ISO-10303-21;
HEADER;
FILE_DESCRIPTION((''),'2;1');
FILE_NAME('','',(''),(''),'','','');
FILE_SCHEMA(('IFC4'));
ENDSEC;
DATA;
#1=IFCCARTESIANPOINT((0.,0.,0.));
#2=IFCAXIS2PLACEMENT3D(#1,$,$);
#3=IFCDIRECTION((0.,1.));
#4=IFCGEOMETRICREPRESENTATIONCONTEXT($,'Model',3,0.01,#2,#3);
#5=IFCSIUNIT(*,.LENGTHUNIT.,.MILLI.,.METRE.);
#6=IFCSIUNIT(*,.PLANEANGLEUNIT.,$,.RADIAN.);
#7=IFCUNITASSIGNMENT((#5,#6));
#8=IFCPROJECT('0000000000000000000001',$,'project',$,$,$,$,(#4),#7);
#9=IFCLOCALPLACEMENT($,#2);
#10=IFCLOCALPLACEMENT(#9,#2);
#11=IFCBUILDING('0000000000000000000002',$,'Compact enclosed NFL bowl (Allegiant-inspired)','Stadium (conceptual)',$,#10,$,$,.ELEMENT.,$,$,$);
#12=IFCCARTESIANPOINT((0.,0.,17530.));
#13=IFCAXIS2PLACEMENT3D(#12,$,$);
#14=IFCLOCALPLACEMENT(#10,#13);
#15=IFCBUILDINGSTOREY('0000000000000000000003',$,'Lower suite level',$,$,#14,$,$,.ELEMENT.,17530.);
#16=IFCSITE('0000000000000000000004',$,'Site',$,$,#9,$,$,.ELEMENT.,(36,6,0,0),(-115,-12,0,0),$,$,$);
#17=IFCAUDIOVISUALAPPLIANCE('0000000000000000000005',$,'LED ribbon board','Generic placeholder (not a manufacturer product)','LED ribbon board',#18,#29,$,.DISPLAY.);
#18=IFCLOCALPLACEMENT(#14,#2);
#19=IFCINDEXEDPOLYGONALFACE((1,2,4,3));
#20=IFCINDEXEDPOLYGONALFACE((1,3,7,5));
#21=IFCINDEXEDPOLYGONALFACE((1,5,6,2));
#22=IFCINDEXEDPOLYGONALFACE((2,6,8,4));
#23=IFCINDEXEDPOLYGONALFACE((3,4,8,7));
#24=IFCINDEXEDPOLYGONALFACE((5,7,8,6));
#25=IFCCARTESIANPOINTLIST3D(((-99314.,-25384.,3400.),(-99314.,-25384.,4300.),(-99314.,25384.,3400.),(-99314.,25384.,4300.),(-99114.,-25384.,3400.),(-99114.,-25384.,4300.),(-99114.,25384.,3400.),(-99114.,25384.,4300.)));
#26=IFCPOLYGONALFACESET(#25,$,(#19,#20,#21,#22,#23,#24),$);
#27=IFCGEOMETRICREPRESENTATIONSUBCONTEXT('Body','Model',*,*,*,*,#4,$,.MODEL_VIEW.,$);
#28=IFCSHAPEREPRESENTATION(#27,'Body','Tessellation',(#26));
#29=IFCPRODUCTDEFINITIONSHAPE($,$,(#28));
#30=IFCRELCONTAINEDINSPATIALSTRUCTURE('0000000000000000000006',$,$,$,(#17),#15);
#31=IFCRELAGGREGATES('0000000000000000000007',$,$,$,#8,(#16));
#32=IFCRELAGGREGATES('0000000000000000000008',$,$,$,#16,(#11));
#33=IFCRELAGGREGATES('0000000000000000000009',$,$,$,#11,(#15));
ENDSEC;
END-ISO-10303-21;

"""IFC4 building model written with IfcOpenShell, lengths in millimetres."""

from ifc_helpers import new_model, si_unit, direction, frame, origin, place, context, subcontext, project, spatial, line, indexed_curve, outline, extrude, element, save


model = new_model("IFC4")

# Units and contexts
model_context = context("Model", 3, precision=0.01, world=origin(), true_north=direction((0.0, 1.0)))
body_context = subcontext(model_context, "Body", "Model", "MODEL_VIEW")
ifc_project = project(units=[si_unit("LENGTHUNIT", "METRE", prefix="MILLI"), si_unit("PLANEANGLEUNIT", "RADIAN")], contexts=[model_context])

# Site, building, storey
site_placement = place(None, origin())
site = spatial("IfcSite", under=ifc_project, at=site_placement, Name="Site", CompositionType="ELEMENT", RefLatitude=(36, 6, 0, 0), RefLongitude=(-115, -12, 0, 0))
building_placement = place(site_placement, origin())
building = spatial("IfcBuilding", under=site, at=building_placement, Name="Compact enclosed NFL bowl (Allegiant-inspired)", Description="Stadium (conceptual)", CompositionType="ELEMENT")
storey_placement = place(building_placement, frame((0.0, 0.0, 17530.0)))
storey = spatial("IfcBuildingStorey", under=building, at=storey_placement, Name="Lower suite level", CompositionType="ELEMENT", Elevation=17530.0)

# Shared definitions
placement = place(storey_placement, frame((0.0, 0.0, -17530.0)))

# Audio visual appliance
element("IfcAudioVisualAppliance", 1, at=placement, inside=storey, Name="LED ribbon board", Description="Generic placeholder (not a manufacturer product)", ObjectType="LED ribbon board", PredefinedType="DISPLAY", context=body_context, shape_type="SweptSolid", body=[
    extrude(outline(indexed_curve([(-99114.0, 25384.0), (-99114.0, -25384.0), (-99314.0, -25384.0), (-99314.0, 25384.0)], segments=[line(1, 2), line(2, 3), line(3, 4), line(4, 1)], self_intersect=False)), frame((0.0, 0.0, 20930.0)), (0.0, 0.0, 1.0), 900.0),
])

save(model, "model.ifc")
